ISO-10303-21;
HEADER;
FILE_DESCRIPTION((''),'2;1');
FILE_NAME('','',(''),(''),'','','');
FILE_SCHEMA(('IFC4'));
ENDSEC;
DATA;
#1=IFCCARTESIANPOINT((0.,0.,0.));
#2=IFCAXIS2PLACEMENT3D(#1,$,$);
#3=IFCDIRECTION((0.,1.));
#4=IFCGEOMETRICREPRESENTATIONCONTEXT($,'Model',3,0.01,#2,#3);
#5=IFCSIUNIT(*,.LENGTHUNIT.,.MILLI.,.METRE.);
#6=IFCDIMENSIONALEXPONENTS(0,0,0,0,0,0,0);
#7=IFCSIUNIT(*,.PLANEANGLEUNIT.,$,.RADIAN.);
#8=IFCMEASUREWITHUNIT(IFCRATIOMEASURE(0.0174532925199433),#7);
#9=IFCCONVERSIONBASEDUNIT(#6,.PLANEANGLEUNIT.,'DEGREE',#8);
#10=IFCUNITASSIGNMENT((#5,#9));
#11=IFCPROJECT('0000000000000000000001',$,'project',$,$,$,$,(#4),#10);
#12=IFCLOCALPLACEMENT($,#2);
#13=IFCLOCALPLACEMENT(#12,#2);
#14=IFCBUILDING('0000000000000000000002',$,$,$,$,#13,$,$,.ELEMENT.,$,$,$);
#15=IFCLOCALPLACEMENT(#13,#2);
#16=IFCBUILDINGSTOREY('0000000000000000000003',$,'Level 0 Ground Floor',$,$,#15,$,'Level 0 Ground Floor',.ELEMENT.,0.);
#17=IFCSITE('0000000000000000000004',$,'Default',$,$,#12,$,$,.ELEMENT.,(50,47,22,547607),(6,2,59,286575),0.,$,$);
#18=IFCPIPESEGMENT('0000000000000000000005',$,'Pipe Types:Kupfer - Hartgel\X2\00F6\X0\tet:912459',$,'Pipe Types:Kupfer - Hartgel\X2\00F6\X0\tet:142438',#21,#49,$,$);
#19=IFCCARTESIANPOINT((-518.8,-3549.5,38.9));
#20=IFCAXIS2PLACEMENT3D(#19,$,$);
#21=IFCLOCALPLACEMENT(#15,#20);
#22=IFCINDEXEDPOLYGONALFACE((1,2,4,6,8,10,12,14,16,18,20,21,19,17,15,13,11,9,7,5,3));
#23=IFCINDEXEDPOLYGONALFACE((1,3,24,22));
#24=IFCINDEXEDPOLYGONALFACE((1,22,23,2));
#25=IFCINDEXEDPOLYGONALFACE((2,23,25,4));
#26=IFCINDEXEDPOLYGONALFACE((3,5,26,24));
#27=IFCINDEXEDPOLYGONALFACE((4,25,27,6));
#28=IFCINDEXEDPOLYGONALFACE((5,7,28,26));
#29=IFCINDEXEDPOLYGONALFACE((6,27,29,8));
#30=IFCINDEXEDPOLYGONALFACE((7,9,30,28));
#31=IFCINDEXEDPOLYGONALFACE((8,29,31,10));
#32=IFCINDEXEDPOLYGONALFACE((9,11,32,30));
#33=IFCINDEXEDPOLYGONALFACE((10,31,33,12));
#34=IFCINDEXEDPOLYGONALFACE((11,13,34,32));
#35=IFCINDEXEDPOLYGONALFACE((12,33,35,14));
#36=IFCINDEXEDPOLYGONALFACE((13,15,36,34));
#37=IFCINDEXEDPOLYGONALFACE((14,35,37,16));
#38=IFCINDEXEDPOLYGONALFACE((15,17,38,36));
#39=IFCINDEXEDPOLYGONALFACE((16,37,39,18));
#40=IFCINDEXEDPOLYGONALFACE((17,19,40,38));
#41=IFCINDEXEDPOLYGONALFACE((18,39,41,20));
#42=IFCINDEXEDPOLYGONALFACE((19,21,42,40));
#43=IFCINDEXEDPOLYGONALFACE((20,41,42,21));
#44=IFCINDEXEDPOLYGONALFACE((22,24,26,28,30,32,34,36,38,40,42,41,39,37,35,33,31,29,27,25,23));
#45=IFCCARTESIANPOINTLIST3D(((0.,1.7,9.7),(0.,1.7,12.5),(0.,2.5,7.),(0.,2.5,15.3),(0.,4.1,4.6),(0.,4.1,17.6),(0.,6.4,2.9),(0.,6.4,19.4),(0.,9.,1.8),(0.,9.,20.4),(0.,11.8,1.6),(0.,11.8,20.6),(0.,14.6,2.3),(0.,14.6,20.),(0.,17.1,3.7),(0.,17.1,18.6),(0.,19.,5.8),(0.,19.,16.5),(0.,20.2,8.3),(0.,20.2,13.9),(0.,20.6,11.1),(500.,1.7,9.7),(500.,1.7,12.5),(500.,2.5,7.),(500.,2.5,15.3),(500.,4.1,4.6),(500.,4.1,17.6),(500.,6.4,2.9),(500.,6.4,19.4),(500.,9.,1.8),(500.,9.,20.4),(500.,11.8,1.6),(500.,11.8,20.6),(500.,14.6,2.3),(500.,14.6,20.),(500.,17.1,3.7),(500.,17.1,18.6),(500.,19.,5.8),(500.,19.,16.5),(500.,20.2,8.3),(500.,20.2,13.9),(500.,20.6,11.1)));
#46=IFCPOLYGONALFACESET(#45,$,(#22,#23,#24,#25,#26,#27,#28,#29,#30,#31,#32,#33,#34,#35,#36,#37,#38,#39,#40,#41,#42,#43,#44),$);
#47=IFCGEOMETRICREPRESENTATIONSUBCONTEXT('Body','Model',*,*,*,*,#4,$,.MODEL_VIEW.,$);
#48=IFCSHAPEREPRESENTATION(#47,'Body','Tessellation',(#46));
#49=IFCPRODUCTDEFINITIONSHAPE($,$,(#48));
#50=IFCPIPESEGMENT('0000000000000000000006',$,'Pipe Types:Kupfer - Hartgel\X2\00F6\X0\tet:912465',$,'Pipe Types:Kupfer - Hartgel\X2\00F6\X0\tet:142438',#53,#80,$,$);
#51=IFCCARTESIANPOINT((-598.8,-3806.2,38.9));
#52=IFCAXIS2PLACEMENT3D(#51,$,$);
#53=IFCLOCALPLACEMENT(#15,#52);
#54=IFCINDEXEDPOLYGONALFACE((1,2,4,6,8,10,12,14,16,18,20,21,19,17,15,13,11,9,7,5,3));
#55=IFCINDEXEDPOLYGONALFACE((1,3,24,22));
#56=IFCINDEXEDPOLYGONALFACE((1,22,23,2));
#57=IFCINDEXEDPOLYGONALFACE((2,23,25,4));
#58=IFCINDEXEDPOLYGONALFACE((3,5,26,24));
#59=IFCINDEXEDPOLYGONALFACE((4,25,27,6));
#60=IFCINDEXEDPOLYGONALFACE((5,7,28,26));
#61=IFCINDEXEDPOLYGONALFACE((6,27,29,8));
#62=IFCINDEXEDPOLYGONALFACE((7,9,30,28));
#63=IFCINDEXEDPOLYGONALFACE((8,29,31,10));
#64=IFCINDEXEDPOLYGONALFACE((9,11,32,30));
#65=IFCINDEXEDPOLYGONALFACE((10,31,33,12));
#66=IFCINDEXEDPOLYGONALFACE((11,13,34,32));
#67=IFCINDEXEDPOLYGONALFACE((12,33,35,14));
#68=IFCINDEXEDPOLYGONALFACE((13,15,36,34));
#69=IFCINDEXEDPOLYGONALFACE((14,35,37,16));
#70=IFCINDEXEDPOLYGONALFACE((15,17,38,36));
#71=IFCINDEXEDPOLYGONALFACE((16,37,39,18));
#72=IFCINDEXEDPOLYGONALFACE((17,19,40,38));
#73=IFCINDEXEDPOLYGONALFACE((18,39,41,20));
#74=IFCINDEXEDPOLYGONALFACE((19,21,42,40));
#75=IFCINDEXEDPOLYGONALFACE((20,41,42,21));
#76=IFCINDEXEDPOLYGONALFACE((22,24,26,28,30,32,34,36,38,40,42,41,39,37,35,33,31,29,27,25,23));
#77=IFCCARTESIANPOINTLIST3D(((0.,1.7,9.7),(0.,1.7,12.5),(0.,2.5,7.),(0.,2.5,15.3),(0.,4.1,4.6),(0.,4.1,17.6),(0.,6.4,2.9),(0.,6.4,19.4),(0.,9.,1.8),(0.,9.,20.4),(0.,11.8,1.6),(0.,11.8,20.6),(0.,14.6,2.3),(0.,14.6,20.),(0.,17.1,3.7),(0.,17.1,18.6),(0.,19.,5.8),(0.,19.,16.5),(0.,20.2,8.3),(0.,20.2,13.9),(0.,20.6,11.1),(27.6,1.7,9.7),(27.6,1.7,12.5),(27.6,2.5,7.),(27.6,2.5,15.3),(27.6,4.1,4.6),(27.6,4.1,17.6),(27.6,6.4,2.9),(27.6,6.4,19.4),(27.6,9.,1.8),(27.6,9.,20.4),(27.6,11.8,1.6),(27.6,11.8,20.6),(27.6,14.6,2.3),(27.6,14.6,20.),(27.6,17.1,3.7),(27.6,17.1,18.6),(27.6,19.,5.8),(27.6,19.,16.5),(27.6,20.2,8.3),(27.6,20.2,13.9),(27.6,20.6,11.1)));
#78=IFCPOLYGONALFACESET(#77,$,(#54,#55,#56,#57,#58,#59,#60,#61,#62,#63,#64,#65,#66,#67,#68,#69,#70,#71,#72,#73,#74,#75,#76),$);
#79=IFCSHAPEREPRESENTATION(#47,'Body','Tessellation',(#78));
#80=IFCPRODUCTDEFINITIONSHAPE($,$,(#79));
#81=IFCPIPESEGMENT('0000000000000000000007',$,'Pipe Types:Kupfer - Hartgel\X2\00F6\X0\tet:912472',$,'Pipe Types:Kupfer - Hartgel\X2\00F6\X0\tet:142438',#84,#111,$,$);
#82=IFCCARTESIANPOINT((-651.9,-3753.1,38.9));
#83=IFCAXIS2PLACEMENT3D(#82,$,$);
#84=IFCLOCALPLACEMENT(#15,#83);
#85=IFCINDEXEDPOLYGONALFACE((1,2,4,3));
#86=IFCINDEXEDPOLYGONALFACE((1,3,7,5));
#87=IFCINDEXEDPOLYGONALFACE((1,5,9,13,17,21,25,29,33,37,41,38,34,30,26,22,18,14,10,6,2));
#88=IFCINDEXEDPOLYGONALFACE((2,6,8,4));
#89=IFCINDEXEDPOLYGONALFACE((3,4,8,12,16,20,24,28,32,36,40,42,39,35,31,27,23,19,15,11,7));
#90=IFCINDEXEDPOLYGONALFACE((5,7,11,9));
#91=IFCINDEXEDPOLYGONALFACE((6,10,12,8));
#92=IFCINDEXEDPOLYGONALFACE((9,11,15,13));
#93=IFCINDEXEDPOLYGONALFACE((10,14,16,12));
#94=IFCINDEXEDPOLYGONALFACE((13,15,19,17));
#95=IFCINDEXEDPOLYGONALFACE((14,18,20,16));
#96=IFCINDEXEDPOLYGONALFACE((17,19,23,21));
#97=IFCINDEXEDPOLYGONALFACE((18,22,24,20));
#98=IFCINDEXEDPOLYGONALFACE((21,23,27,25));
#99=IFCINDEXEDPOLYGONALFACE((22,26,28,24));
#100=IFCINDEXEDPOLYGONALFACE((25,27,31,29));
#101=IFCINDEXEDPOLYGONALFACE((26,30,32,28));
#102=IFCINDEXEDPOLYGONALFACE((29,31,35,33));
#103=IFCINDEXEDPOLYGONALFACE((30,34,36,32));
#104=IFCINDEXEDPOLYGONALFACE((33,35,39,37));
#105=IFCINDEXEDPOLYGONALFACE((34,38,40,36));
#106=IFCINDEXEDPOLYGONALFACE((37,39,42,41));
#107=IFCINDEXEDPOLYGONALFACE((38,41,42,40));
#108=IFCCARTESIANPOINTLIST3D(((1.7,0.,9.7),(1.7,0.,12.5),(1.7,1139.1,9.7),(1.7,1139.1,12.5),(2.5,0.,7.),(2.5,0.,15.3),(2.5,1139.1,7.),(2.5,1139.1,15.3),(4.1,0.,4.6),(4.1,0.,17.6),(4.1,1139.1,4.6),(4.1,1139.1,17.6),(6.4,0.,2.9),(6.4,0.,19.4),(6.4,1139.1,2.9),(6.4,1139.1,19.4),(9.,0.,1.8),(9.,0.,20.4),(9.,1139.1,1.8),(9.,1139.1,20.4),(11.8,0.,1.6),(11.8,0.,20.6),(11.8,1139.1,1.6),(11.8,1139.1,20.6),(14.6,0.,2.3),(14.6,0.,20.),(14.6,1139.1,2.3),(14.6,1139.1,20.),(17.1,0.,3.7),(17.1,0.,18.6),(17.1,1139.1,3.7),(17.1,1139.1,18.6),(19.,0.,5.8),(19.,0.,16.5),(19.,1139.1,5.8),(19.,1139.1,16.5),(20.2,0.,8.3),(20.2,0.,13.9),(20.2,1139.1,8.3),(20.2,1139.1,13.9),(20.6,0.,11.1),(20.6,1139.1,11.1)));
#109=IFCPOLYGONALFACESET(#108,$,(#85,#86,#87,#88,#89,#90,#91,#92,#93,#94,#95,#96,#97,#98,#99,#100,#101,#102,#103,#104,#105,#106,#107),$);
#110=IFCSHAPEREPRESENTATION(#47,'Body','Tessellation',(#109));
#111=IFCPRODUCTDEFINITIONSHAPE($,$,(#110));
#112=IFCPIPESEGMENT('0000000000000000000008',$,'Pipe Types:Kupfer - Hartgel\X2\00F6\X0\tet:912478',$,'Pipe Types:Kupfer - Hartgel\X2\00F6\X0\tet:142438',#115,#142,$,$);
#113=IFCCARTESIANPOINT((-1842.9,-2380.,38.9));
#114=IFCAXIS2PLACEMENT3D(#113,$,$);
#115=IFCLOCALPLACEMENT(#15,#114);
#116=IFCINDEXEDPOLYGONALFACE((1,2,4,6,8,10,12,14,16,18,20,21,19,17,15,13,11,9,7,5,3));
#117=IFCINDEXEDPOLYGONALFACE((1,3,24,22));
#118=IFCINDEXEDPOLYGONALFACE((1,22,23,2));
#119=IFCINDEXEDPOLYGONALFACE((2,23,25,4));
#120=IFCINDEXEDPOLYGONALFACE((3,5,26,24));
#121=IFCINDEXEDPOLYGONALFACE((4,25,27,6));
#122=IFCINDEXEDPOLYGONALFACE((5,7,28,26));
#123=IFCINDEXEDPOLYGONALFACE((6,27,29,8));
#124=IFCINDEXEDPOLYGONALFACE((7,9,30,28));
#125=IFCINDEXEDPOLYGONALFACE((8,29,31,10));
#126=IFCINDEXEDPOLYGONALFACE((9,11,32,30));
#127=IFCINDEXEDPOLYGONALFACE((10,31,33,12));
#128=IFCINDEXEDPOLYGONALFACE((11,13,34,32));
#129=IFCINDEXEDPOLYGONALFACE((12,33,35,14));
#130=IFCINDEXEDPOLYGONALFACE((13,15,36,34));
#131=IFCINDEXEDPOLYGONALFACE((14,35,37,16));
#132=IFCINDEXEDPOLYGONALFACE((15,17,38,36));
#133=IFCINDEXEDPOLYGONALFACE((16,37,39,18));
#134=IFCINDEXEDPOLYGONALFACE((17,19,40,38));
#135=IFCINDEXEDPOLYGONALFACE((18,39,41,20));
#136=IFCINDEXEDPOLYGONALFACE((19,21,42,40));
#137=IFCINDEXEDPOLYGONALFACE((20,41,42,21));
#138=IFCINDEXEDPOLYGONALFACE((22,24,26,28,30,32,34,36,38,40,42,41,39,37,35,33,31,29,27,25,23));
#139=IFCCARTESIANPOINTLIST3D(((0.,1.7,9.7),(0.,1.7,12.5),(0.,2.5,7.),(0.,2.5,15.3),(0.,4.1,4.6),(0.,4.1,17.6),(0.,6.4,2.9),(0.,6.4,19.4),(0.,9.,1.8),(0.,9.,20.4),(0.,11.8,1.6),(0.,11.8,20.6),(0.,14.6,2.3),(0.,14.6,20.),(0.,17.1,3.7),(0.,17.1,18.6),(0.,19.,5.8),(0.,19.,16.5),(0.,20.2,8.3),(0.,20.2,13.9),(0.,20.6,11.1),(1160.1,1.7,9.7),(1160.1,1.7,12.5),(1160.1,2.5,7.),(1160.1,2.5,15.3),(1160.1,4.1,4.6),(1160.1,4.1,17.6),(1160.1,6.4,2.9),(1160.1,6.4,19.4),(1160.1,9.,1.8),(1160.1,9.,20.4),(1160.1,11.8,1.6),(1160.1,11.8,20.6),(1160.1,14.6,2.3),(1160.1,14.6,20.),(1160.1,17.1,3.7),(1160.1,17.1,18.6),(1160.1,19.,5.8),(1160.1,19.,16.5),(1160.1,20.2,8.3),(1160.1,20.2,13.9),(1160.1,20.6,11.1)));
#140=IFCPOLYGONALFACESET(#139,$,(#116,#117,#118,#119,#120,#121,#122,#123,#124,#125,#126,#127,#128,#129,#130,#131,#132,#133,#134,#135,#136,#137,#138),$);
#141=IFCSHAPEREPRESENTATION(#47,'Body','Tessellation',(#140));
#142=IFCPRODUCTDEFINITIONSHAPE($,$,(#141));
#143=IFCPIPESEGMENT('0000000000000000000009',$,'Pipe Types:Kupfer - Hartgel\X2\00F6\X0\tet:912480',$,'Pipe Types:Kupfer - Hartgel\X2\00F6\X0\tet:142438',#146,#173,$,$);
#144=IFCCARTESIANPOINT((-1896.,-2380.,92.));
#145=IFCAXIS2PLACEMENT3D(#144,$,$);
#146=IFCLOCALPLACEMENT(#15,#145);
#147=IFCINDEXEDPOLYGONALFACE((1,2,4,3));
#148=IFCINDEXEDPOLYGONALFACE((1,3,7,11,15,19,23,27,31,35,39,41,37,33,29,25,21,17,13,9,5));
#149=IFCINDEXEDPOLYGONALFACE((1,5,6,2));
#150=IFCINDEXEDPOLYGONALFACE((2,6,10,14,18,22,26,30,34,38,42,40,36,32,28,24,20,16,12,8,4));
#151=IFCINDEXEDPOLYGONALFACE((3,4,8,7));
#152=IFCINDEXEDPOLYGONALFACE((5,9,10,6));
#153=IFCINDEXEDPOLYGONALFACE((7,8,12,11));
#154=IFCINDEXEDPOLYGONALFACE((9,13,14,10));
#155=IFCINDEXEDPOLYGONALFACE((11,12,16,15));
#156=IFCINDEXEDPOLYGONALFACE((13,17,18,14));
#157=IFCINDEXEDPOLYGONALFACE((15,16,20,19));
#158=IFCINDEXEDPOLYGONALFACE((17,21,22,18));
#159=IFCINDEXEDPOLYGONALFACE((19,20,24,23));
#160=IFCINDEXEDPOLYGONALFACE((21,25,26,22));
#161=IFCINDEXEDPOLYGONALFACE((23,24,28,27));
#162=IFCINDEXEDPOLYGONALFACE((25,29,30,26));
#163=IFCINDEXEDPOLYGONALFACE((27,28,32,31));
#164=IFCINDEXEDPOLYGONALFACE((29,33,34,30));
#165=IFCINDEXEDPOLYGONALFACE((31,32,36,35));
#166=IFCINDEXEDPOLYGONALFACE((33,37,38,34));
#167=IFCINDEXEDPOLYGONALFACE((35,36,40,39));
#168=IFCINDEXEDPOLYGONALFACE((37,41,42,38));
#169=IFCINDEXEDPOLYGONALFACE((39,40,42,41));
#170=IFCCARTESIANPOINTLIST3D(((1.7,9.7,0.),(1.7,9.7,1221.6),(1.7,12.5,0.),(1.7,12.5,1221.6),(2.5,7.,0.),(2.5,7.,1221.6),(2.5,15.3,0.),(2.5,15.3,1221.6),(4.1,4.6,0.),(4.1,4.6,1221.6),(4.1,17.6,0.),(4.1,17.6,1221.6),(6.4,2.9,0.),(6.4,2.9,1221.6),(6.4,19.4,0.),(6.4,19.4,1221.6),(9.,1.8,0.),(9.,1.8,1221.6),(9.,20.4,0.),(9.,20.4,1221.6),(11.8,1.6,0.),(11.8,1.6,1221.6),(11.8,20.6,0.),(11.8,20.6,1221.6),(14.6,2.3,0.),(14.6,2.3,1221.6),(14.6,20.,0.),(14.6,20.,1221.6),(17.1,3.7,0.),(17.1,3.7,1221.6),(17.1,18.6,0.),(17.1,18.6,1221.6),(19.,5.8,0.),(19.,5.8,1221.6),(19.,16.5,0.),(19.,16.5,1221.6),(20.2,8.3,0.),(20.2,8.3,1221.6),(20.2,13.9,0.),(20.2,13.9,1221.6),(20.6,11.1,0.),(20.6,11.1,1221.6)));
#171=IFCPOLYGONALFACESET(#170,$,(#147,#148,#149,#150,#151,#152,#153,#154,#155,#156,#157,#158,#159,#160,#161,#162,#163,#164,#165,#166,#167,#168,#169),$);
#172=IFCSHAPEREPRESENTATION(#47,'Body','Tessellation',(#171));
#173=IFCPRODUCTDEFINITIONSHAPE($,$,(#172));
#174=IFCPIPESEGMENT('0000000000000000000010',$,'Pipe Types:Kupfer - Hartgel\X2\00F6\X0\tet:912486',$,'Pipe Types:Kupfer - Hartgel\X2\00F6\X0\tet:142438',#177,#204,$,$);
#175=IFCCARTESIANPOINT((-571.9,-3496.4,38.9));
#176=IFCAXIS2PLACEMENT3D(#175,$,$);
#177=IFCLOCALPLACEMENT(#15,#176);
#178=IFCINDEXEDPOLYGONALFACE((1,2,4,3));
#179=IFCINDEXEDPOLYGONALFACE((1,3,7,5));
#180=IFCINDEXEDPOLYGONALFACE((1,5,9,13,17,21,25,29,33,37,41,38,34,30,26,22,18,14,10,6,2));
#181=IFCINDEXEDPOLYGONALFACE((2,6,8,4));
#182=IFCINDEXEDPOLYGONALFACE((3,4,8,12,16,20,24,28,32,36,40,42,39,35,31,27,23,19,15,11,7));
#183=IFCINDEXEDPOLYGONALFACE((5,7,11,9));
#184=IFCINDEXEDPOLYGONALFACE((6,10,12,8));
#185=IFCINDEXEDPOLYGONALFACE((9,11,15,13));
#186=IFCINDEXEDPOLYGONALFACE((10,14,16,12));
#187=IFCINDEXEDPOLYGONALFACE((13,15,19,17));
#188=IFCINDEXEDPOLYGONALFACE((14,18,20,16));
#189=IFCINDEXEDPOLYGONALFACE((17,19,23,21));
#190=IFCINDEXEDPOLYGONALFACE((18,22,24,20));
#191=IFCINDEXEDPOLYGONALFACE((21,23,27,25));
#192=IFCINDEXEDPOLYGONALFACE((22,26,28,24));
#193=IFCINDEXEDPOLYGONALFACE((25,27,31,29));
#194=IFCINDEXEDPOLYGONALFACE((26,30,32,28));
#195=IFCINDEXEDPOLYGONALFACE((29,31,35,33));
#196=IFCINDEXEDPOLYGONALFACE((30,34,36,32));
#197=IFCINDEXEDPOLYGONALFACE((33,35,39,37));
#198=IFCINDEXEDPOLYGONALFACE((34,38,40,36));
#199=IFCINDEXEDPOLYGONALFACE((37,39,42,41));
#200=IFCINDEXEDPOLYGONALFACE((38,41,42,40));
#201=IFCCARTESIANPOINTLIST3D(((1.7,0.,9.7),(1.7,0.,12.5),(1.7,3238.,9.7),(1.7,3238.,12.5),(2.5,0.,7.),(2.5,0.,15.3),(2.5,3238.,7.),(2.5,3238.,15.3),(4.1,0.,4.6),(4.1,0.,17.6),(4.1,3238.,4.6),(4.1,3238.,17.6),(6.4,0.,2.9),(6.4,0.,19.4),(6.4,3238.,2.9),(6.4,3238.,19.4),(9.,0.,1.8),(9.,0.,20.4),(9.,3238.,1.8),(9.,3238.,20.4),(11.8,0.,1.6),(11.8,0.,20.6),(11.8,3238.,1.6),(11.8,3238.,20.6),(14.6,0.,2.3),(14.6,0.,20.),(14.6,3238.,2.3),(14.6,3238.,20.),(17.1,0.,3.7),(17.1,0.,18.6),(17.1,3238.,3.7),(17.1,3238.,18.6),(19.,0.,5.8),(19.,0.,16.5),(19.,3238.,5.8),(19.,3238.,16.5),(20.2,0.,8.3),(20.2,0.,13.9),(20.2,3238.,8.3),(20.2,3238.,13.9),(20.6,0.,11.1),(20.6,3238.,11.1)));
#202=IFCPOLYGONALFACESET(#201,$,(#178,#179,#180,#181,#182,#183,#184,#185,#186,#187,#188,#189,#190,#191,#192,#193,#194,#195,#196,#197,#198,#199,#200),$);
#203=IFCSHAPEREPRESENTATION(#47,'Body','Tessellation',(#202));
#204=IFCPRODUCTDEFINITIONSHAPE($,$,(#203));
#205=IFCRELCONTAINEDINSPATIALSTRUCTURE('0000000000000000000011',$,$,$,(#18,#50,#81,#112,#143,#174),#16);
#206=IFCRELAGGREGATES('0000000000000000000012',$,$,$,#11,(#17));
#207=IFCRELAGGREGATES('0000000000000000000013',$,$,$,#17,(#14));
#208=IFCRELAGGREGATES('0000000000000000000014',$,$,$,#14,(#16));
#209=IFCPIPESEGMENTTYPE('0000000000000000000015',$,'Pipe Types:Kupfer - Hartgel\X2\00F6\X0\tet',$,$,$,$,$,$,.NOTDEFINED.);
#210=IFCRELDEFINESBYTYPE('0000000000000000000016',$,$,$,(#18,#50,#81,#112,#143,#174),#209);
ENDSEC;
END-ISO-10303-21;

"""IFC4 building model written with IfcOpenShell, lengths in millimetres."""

from ifc_helpers import new_model, entity, si_unit, converted_unit, direction, frame, frame_2d, origin, origin_2d_with_axis, place, context, subcontext, project, spatial, circle, extrude, type_object, element, save


model = new_model("IFC4")

# Units and contexts
model_context = context("Model", 3, precision=0.01, world=origin(), true_north=direction((0.0, 1.0)))
body_context = subcontext(model_context, "Body", "Model", "MODEL_VIEW")
ifc_project = project(units=[si_unit("LENGTHUNIT", "METRE", prefix="MILLI"), converted_unit("PLANEANGLEUNIT", "DEGREE", entity("IfcRatioMeasure", 0.0174532925199433), si_unit("PLANEANGLEUNIT", "RADIAN"), dimensions=[0, 0, 0, 0, 0, 0, 0])], contexts=[model_context])

# Site, building, storey
site_placement = place(None, origin())
site = spatial("IfcSite", under=ifc_project, at=site_placement, Name="Default", CompositionType="ELEMENT", RefLatitude=(50, 47, 22, 547607), RefLongitude=(6, 2, 59, 286575), RefElevation=0.0)
building_placement = place(site_placement, origin())
building = spatial("IfcBuilding", under=site, at=building_placement, CompositionType="ELEMENT")
storey_placement = place(building_placement, origin())
storey = spatial("IfcBuildingStorey", under=building, at=storey_placement, Name="Level 0 Ground Floor", LongName="Level 0 Ground Floor", CompositionType="ELEMENT", Elevation=0.0)

# Pipe segments
pipe_segment_type = type_object("IfcPipeSegmentType", Name="Pipe Types:Kupfer - Hartgelötet", PredefinedType="NOTDEFINED")
pipe_segment_1_placement = place(storey_placement, frame((-518.8, -3549.5, 38.9)))
element("IfcPipeSegment", 1, at=pipe_segment_1_placement, inside=storey, type_object=pipe_segment_type, Name="Pipe Types:Kupfer - Hartgelötet:912459", ObjectType="Pipe Types:Kupfer - Hartgelötet:142438", context=body_context, shape_type="SweptSolid", body=[
    extrude(circle(Radius=9.5, at=frame_2d((0.0, 0.0), x_axis=(1.0, 0.0))), frame((0.0, 11.1, 11.1), z_axis=(1.0, 0.0, 0.0), x_axis=(0.0, 1.0, 0.0)), (0.0, 0.0, 1.0), 500.0),
])
pipe_segment_2_placement = place(storey_placement, frame((-598.8, -3806.2, 38.9)))
element("IfcPipeSegment", 2, at=pipe_segment_2_placement, inside=storey, type_object=pipe_segment_type, Name="Pipe Types:Kupfer - Hartgelötet:912465", ObjectType="Pipe Types:Kupfer - Hartgelötet:142438", context=body_context, shape_type="SweptSolid", body=[
    extrude(circle(Radius=9.5, at=frame_2d((0.0, 0.0), x_axis=(1.0, 0.0))), frame((0.0, 11.1, 11.1), z_axis=(1.0, 0.0, 0.0), x_axis=(0.0, 1.0, 0.0)), (0.0, 0.0, 1.0), 27.6),
])
pipe_segment_3_placement = place(storey_placement, frame((-651.9, -3753.1, 38.9)))
element("IfcPipeSegment", 3, at=pipe_segment_3_placement, inside=storey, type_object=pipe_segment_type, Name="Pipe Types:Kupfer - Hartgelötet:912472", ObjectType="Pipe Types:Kupfer - Hartgelötet:142438", context=body_context, shape_type="SweptSolid", body=[
    extrude(circle(Radius=9.5, at=frame_2d((0.0, 0.0), x_axis=(1.0, 0.0))), frame((11.1, 0.0, 11.1), z_axis=(0.0, 1.0, 0.0), x_axis=(1.0, 0.0, 0.0)), (0.0, 0.0, 1.0), 1139.1),
])
pipe_segment_4_placement = place(storey_placement, frame((-1842.9, -2380.0, 38.9)))
element("IfcPipeSegment", 4, at=pipe_segment_4_placement, inside=storey, type_object=pipe_segment_type, Name="Pipe Types:Kupfer - Hartgelötet:912478", ObjectType="Pipe Types:Kupfer - Hartgelötet:142438", context=body_context, shape_type="SweptSolid", body=[
    extrude(circle(Radius=9.5, at=frame_2d((0.0, 0.0), x_axis=(1.0, 0.0))), frame((0.0, 11.1, 11.1), z_axis=(1.0, 0.0, 0.0), x_axis=(0.0, 1.0, 0.0)), (0.0, 0.0, 1.0), 1160.1),
])
pipe_segment_5_placement = place(storey_placement, frame((-1896.0, -2380.0, 92.0)))
element("IfcPipeSegment", 5, at=pipe_segment_5_placement, inside=storey, type_object=pipe_segment_type, Name="Pipe Types:Kupfer - Hartgelötet:912480", ObjectType="Pipe Types:Kupfer - Hartgelötet:142438", context=body_context, shape_type="SweptSolid", body=[
    extrude(circle(Radius=9.5, at=origin_2d_with_axis()), frame((11.1, 11.1, 0.0)), (0.0, 0.0, 1.0), 1221.6),
])
pipe_segment_6_placement = place(storey_placement, frame((-571.9, -3496.4, 38.9)))
element("IfcPipeSegment", 6, at=pipe_segment_6_placement, inside=storey, type_object=pipe_segment_type, Name="Pipe Types:Kupfer - Hartgelötet:912486", ObjectType="Pipe Types:Kupfer - Hartgelötet:142438", context=body_context, shape_type="SweptSolid", body=[
    extrude(circle(Radius=9.5, at=frame_2d((0.0, 0.0), x_axis=(1.0, 0.0))), frame((11.1, 0.0, 11.1), z_axis=(0.0, 1.0, 0.0), x_axis=(1.0, 0.0, 0.0)), (0.0, 0.0, 1.0), 3238.0),
])

save(model, "model.ifc")
